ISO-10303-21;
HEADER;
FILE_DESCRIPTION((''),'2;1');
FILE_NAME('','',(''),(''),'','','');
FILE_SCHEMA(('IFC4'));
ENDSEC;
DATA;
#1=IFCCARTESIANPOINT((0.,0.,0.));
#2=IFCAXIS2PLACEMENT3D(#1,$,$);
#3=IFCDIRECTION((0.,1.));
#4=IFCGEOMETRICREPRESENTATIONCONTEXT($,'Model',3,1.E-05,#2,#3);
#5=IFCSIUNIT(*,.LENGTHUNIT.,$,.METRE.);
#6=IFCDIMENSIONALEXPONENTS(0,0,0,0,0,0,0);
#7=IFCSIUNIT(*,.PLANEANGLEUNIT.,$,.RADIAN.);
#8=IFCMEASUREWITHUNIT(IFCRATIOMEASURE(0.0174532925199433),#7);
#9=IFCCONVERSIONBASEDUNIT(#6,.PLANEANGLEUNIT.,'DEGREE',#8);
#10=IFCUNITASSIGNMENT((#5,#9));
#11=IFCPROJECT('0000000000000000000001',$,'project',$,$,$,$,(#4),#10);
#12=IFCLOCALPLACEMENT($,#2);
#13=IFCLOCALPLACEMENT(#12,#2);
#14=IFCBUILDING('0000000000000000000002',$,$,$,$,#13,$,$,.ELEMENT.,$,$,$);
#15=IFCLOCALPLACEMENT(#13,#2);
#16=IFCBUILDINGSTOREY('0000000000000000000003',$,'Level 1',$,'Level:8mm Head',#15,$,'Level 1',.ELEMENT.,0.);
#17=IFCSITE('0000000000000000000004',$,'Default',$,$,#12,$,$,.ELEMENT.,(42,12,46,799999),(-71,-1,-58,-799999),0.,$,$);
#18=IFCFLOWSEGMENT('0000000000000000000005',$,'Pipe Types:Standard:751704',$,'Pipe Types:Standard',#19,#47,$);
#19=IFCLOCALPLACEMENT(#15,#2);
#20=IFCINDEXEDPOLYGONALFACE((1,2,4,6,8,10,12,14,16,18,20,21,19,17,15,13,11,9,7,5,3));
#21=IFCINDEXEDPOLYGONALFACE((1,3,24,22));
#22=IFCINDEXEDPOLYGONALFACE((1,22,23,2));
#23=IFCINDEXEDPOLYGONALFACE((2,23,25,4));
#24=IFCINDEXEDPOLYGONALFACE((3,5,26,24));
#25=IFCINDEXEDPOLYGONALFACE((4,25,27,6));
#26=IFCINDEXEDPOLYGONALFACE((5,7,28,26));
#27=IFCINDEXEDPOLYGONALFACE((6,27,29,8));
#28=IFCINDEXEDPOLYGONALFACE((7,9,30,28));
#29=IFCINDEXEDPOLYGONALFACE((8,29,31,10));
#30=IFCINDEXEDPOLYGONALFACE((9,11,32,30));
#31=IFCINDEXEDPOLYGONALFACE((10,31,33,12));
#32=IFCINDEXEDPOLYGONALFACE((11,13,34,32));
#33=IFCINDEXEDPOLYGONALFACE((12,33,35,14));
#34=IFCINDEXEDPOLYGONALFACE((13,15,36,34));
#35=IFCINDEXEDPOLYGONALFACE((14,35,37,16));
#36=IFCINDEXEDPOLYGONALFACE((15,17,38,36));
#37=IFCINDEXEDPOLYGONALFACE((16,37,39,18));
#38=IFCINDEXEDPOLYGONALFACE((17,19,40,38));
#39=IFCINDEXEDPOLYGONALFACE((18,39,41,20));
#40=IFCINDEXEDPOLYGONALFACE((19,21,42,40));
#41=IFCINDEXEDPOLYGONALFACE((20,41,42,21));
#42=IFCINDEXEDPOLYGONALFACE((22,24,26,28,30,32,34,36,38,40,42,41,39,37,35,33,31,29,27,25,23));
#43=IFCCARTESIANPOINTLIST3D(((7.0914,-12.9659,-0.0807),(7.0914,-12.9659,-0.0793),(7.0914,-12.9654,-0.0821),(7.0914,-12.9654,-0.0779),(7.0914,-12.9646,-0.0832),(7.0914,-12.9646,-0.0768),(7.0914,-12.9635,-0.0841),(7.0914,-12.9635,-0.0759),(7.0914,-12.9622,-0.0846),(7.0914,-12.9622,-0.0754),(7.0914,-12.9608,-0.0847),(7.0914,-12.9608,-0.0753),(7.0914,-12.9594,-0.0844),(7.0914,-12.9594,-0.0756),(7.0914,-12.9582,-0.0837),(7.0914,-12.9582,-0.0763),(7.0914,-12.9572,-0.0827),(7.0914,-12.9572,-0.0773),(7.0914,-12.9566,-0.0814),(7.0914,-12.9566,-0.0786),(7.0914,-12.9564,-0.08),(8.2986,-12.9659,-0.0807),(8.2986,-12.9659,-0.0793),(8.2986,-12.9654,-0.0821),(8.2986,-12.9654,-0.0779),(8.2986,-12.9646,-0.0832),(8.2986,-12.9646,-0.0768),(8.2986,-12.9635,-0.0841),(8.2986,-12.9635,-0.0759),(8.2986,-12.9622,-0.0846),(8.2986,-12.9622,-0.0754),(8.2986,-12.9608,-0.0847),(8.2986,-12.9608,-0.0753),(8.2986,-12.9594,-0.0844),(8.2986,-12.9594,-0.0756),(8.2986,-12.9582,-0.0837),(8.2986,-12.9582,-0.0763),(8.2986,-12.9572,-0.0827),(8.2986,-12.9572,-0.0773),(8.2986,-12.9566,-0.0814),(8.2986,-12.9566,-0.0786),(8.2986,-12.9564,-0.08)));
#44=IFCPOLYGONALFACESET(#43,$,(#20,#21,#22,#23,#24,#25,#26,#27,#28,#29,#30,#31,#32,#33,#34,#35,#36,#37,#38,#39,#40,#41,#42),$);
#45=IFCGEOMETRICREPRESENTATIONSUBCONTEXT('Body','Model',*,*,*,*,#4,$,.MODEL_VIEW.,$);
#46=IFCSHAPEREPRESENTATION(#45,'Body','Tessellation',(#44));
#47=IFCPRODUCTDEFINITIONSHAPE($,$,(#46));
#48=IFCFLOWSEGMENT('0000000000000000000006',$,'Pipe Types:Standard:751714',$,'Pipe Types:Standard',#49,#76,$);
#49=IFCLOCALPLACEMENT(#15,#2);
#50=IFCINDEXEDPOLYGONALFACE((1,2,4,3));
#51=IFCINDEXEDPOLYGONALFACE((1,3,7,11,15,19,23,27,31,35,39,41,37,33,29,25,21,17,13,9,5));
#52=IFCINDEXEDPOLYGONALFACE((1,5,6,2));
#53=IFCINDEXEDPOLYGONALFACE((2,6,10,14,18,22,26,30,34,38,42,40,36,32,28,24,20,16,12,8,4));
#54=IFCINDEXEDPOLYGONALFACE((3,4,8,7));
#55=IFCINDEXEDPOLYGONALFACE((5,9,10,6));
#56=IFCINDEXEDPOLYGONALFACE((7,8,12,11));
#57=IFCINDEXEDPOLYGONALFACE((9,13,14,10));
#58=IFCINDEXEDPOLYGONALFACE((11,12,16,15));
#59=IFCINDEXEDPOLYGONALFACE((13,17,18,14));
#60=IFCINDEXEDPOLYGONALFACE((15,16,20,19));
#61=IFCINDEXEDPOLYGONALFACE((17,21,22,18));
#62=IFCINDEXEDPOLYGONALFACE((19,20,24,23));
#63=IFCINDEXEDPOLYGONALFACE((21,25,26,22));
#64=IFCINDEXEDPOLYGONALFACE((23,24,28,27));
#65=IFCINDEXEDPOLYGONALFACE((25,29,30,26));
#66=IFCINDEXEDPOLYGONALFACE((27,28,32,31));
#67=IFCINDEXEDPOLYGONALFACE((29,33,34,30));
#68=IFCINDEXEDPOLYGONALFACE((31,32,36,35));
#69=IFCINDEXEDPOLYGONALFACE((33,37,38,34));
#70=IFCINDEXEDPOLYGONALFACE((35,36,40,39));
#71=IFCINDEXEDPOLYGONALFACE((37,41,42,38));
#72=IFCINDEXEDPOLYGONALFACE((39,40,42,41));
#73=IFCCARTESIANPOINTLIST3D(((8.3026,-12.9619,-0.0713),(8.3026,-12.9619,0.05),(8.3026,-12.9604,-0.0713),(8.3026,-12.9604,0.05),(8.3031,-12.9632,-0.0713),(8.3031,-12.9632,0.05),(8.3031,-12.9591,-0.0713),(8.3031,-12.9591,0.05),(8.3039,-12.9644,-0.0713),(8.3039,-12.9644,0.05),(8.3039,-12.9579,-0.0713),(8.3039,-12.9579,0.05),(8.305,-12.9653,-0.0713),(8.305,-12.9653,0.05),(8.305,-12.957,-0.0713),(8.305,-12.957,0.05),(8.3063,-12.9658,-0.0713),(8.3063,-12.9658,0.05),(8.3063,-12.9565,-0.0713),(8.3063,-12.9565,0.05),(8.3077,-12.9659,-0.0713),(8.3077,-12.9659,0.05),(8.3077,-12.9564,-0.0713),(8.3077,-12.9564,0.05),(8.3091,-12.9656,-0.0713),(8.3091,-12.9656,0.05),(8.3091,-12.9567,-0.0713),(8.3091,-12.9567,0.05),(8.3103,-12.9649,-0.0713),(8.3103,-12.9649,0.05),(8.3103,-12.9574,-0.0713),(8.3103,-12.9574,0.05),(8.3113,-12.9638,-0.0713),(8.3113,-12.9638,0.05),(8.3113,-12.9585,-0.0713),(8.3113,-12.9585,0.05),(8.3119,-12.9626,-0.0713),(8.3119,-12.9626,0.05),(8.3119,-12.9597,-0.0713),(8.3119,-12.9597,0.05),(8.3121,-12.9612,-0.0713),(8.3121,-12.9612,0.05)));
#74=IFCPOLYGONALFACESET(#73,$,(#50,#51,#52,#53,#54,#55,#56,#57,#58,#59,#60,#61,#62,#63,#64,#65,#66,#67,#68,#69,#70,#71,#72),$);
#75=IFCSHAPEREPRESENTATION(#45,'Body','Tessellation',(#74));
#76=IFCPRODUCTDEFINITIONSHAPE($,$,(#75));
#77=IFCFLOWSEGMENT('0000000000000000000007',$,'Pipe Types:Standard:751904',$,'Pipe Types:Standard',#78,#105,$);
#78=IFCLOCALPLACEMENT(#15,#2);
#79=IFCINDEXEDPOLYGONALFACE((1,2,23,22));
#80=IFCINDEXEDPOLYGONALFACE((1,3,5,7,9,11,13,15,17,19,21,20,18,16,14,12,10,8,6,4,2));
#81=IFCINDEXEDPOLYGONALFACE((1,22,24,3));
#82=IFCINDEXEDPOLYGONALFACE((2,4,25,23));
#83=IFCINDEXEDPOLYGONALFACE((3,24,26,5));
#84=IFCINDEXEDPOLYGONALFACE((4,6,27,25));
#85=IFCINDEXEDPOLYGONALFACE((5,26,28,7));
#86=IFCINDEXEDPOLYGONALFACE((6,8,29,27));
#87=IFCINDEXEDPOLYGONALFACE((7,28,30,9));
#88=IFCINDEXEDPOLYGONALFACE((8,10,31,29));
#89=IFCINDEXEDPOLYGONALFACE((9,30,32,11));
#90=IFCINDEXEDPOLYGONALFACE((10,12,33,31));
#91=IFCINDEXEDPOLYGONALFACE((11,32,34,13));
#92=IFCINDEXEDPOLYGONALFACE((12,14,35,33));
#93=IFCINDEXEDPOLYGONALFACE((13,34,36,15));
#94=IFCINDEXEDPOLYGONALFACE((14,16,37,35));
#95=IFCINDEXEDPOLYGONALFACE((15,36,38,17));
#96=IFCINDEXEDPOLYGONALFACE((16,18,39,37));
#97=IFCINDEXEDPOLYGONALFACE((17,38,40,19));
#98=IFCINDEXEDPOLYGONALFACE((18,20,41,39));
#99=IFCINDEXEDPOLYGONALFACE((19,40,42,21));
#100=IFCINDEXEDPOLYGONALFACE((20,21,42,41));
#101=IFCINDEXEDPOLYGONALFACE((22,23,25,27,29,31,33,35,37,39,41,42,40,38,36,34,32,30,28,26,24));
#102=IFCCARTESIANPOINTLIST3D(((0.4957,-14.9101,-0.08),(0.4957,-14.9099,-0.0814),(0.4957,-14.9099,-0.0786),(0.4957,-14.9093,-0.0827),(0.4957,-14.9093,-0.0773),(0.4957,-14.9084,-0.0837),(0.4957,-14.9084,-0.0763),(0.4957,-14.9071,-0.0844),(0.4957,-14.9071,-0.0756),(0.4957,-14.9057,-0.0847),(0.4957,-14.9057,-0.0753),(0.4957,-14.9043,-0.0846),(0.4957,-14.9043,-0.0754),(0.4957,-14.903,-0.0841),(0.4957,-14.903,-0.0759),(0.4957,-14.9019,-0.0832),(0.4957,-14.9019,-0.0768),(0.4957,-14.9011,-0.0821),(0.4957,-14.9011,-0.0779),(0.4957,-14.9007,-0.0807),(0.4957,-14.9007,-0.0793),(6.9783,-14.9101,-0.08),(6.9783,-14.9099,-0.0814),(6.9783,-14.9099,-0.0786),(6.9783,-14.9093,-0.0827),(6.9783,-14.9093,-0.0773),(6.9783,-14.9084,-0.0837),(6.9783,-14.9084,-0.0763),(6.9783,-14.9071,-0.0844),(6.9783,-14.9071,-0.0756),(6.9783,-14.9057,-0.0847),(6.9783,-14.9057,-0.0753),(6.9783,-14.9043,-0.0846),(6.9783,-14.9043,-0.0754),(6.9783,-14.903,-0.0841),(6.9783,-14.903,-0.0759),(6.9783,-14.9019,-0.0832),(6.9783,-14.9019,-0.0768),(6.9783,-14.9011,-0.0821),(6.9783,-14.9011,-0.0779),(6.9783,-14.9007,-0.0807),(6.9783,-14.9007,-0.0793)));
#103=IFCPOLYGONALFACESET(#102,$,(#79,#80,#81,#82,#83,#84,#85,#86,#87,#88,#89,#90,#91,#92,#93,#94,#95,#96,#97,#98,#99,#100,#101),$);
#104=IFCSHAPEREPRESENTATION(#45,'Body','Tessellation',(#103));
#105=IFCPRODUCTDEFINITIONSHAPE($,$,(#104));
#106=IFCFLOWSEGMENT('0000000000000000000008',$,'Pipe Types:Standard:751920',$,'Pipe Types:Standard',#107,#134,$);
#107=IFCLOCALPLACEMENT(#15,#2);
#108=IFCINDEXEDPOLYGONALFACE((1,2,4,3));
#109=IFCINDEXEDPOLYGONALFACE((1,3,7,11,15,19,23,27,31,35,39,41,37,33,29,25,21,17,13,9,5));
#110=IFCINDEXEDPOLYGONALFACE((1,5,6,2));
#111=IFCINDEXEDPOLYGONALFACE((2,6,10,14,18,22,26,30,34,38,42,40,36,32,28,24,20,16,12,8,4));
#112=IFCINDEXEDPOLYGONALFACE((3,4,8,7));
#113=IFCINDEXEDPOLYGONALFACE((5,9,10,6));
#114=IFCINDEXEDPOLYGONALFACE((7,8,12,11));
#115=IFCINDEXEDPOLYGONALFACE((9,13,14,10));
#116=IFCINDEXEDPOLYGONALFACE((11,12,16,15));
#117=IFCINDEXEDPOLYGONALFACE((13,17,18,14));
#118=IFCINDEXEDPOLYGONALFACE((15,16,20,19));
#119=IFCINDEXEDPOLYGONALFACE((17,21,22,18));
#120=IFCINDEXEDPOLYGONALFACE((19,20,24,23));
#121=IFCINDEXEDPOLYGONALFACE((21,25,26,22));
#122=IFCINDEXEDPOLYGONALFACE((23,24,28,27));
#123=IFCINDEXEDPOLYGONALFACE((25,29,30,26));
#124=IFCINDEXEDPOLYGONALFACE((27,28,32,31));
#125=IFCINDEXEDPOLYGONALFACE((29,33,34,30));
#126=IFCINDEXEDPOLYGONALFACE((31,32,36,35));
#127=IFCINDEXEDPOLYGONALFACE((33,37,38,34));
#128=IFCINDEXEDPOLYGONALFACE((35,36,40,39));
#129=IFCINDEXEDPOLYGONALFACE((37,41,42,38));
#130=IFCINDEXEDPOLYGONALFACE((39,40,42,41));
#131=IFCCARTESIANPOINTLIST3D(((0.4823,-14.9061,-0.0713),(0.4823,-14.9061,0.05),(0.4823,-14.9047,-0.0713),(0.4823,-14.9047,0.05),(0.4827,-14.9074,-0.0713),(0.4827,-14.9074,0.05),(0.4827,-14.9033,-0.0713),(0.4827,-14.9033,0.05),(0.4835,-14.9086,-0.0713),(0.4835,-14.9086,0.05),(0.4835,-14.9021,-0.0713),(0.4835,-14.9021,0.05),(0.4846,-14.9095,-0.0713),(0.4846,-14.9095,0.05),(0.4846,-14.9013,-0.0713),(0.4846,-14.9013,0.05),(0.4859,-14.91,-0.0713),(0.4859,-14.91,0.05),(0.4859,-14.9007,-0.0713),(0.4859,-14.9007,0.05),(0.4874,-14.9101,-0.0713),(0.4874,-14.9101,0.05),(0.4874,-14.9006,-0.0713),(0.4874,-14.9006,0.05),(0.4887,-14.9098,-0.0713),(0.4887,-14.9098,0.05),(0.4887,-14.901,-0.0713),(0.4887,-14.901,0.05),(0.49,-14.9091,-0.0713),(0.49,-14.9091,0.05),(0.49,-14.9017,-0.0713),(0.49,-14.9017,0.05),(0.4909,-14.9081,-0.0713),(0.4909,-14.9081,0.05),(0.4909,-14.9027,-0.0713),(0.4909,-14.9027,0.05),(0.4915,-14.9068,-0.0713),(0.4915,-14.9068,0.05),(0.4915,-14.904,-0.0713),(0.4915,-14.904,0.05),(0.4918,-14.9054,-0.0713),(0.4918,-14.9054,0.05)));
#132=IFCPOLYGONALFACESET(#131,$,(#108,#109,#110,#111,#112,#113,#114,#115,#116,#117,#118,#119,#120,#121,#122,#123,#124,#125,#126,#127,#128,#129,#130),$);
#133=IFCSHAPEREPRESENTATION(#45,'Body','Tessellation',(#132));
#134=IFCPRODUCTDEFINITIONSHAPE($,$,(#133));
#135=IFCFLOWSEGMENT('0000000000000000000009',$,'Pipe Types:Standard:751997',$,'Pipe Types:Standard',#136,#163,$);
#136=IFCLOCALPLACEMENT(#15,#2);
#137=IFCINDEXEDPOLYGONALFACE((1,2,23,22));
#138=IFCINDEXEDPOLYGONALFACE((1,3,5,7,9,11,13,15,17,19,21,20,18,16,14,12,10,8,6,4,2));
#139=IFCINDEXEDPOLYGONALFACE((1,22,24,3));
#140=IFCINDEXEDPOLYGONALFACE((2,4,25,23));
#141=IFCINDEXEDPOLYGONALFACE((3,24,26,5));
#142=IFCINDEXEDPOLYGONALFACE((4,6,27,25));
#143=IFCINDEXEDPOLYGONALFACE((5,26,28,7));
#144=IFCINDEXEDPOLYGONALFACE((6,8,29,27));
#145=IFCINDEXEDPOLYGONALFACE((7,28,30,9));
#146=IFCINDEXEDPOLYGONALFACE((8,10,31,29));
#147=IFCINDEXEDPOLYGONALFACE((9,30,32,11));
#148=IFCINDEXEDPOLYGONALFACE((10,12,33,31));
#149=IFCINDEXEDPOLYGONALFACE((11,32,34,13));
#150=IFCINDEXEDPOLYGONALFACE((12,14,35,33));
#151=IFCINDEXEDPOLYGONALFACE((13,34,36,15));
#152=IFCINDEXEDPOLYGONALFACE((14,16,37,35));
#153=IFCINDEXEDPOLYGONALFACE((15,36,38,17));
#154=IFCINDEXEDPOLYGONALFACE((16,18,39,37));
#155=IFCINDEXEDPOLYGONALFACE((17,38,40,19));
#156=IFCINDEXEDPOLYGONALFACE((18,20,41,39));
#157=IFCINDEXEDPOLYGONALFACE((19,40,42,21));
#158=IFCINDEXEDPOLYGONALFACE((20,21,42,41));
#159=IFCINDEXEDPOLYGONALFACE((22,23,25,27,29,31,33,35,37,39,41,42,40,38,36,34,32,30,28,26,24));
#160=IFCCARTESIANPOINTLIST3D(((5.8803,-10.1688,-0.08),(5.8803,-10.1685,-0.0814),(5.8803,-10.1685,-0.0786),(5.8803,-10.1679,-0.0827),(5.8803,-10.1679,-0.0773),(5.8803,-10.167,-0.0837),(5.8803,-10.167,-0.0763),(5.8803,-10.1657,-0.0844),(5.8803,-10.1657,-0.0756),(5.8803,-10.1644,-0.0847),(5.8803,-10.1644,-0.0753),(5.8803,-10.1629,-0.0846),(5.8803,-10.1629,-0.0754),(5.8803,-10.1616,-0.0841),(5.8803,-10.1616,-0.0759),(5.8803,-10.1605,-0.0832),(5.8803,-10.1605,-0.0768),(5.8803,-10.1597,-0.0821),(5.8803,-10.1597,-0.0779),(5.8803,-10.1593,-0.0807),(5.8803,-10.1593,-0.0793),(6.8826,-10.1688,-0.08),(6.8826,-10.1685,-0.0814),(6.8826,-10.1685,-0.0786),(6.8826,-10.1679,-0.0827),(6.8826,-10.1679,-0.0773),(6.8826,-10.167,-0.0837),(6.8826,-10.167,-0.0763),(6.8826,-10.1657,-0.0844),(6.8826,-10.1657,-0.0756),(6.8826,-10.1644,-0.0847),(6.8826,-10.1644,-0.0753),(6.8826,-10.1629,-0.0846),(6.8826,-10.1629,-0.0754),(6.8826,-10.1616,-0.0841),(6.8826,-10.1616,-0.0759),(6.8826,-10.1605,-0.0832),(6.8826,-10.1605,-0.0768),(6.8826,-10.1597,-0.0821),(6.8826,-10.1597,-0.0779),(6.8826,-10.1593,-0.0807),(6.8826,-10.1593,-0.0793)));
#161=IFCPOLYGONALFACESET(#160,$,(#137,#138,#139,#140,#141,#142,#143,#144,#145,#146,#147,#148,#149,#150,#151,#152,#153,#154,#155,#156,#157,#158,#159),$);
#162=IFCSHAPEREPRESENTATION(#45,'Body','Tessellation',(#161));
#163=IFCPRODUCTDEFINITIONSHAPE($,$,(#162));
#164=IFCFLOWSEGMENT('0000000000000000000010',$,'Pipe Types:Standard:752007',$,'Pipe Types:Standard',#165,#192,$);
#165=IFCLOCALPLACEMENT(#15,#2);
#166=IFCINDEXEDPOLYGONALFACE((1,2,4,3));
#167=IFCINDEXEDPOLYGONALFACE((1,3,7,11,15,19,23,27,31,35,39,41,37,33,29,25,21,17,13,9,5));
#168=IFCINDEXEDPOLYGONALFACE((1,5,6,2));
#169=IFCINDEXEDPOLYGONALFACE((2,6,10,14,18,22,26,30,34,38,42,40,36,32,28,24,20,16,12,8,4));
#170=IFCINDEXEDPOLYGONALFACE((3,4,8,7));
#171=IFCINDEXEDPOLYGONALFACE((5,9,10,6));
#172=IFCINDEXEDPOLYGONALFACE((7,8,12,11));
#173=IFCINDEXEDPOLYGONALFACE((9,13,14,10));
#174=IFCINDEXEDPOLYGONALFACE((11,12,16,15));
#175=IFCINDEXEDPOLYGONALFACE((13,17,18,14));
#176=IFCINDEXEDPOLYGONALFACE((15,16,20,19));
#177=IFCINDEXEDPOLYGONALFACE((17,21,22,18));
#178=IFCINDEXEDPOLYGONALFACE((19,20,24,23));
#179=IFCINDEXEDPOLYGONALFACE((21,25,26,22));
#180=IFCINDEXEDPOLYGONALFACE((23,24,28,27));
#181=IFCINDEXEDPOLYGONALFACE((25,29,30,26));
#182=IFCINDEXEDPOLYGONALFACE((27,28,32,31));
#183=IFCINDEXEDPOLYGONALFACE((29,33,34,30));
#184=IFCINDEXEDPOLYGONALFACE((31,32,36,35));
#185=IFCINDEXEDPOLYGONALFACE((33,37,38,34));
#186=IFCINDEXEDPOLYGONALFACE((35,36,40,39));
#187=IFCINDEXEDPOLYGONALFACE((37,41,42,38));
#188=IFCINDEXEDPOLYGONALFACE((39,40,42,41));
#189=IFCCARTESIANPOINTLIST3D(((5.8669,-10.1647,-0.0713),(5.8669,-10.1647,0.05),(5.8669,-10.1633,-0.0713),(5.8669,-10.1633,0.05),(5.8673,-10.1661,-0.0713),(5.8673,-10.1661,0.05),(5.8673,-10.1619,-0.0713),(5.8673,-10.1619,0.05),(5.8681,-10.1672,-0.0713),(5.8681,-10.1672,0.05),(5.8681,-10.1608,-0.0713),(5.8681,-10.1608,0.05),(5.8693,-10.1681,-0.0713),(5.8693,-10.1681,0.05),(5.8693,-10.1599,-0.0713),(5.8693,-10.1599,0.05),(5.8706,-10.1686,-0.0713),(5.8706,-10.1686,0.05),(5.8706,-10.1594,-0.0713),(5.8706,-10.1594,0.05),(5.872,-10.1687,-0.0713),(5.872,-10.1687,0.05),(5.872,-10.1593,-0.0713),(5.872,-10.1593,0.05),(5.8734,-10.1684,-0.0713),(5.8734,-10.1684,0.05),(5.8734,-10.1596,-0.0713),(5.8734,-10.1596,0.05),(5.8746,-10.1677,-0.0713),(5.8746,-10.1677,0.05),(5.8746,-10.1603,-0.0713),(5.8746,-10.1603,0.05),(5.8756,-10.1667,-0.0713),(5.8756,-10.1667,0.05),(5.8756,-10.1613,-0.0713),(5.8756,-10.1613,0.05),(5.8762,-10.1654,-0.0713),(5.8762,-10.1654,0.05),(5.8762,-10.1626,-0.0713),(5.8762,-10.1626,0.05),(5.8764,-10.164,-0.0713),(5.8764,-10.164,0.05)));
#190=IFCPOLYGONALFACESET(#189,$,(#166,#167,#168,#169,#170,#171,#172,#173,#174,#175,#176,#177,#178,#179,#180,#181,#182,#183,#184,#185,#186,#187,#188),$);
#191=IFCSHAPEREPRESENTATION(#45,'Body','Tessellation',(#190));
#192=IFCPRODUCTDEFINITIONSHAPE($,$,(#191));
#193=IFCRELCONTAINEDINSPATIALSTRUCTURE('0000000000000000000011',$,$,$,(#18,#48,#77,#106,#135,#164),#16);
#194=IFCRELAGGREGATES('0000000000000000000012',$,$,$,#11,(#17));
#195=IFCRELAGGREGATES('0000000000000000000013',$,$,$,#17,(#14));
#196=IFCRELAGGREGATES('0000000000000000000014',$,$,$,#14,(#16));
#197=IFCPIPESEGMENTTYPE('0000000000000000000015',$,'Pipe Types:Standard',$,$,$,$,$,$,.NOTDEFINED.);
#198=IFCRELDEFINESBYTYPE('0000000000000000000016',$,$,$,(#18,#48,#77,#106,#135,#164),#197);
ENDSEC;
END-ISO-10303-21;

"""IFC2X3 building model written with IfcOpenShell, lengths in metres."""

from ifc_helpers import new_model, entity, si_unit, converted_unit, direction, frame, frame_2d, origin, origin_2d_with_axis, place, context, subcontext, project, spatial, circle, extrude, type_object, element, save


model = new_model("IFC2X3")

# Units and contexts
model_context = context("Model", 3, precision=1e-05, world=origin(), true_north=direction((0.0, 1.0)))
body_context = subcontext(model_context, "Body", "Model", "MODEL_VIEW")
ifc_project = project(units=[si_unit("LENGTHUNIT", "METRE"), converted_unit("PLANEANGLEUNIT", "DEGREE", entity("IfcRatioMeasure", 0.0174532925199433), si_unit("PLANEANGLEUNIT", "RADIAN"), dimensions=[0, 0, 0, 0, 0, 0, 0])], contexts=[model_context])

# Site, building, storey
site_placement = place(None, origin())
site = spatial("IfcSite", under=ifc_project, at=site_placement, Name="Default", CompositionType="ELEMENT", RefLatitude=(42, 12, 46, 799999), RefLongitude=(-71, -1, -58, -799999), RefElevation=0.0)
building_placement = place(site_placement, origin())
building = spatial("IfcBuilding", under=site, at=building_placement, CompositionType="ELEMENT")
storey_placement = place(building_placement, origin())
storey = spatial("IfcBuildingStorey", under=building, at=storey_placement, Name="Level 1", ObjectType="Level:8mm Head", LongName="Level 1", CompositionType="ELEMENT", Elevation=0.0)

# Flow segments
pipe_segment_type = type_object("IfcPipeSegmentType", Name="Pipe Types:Standard", PredefinedType="NOTDEFINED")
flow_segment_1_placement = place(storey_placement, origin())
element("IfcFlowSegment", 1, at=flow_segment_1_placement, inside=storey, type_object=pipe_segment_type, Name="Pipe Types:Standard:751704", ObjectType="Pipe Types:Standard", context=body_context, shape_type="SweptSolid", body=[
    extrude(circle(Radius=0.0048, at=frame_2d((0.0, 0.0), x_axis=(1.0, 0.0))), frame((7.0914, -12.9612, -0.08), z_axis=(1.0, 0.0, 0.0), x_axis=(0.0, 1.0, 0.0)), (0.0, 0.0, 1.0), 1.2072),
])
flow_segment_2_placement = place(storey_placement, origin())
element("IfcFlowSegment", 2, at=flow_segment_2_placement, inside=storey, type_object=pipe_segment_type, Name="Pipe Types:Standard:751714", ObjectType="Pipe Types:Standard", context=body_context, shape_type="SweptSolid", body=[
    extrude(circle(Radius=0.0048, at=frame_2d((0.0, 0.0), x_axis=(1.0, 0.0))), frame((8.3074, -12.9612, -0.0713)), (0.0, 0.0, 1.0), 0.1213),
])
flow_segment_3_placement = place(storey_placement, origin())
element("IfcFlowSegment", 3, at=flow_segment_3_placement, inside=storey, type_object=pipe_segment_type, Name="Pipe Types:Standard:751904", ObjectType="Pipe Types:Standard", context=body_context, shape_type="SweptSolid", body=[
    extrude(circle(Radius=0.0048, at=origin_2d_with_axis()), frame((0.4957, -14.9054, -0.08), z_axis=(1.0, 0.0, 0.0), x_axis=(0.0, -1.0, 0.0)), (0.0, 0.0, 1.0), 6.4826),
])
flow_segment_4_placement = place(storey_placement, origin())
element("IfcFlowSegment", 4, at=flow_segment_4_placement, inside=storey, type_object=pipe_segment_type, Name="Pipe Types:Standard:751920", ObjectType="Pipe Types:Standard", context=body_context, shape_type="SweptSolid", body=[
    extrude(circle(Radius=0.0048, at=origin_2d_with_axis()), frame((0.487, -14.9054, -0.0713)), (0.0, 0.0, 1.0), 0.1213),
])
flow_segment_5_placement = place(storey_placement, origin())
element("IfcFlowSegment", 5, at=flow_segment_5_placement, inside=storey, type_object=pipe_segment_type, Name="Pipe Types:Standard:751997", ObjectType="Pipe Types:Standard", context=body_context, shape_type="SweptSolid", body=[
    extrude(circle(Radius=0.0048, at=origin_2d_with_axis()), frame((5.8803, -10.164, -0.08), z_axis=(1.0, 0.0, 0.0), x_axis=(0.0, -1.0, 0.0)), (0.0, 0.0, 1.0), 1.0022),
])
flow_segment_6_placement = place(storey_placement, origin())
element("IfcFlowSegment", 6, at=flow_segment_6_placement, inside=storey, type_object=pipe_segment_type, Name="Pipe Types:Standard:752007", ObjectType="Pipe Types:Standard", context=body_context, shape_type="SweptSolid", body=[
    extrude(circle(Radius=0.0048, at=origin_2d_with_axis()), frame((5.8716, -10.164, -0.0713)), (0.0, 0.0, 1.0), 0.1213),
])

save(model, "model.ifc")
